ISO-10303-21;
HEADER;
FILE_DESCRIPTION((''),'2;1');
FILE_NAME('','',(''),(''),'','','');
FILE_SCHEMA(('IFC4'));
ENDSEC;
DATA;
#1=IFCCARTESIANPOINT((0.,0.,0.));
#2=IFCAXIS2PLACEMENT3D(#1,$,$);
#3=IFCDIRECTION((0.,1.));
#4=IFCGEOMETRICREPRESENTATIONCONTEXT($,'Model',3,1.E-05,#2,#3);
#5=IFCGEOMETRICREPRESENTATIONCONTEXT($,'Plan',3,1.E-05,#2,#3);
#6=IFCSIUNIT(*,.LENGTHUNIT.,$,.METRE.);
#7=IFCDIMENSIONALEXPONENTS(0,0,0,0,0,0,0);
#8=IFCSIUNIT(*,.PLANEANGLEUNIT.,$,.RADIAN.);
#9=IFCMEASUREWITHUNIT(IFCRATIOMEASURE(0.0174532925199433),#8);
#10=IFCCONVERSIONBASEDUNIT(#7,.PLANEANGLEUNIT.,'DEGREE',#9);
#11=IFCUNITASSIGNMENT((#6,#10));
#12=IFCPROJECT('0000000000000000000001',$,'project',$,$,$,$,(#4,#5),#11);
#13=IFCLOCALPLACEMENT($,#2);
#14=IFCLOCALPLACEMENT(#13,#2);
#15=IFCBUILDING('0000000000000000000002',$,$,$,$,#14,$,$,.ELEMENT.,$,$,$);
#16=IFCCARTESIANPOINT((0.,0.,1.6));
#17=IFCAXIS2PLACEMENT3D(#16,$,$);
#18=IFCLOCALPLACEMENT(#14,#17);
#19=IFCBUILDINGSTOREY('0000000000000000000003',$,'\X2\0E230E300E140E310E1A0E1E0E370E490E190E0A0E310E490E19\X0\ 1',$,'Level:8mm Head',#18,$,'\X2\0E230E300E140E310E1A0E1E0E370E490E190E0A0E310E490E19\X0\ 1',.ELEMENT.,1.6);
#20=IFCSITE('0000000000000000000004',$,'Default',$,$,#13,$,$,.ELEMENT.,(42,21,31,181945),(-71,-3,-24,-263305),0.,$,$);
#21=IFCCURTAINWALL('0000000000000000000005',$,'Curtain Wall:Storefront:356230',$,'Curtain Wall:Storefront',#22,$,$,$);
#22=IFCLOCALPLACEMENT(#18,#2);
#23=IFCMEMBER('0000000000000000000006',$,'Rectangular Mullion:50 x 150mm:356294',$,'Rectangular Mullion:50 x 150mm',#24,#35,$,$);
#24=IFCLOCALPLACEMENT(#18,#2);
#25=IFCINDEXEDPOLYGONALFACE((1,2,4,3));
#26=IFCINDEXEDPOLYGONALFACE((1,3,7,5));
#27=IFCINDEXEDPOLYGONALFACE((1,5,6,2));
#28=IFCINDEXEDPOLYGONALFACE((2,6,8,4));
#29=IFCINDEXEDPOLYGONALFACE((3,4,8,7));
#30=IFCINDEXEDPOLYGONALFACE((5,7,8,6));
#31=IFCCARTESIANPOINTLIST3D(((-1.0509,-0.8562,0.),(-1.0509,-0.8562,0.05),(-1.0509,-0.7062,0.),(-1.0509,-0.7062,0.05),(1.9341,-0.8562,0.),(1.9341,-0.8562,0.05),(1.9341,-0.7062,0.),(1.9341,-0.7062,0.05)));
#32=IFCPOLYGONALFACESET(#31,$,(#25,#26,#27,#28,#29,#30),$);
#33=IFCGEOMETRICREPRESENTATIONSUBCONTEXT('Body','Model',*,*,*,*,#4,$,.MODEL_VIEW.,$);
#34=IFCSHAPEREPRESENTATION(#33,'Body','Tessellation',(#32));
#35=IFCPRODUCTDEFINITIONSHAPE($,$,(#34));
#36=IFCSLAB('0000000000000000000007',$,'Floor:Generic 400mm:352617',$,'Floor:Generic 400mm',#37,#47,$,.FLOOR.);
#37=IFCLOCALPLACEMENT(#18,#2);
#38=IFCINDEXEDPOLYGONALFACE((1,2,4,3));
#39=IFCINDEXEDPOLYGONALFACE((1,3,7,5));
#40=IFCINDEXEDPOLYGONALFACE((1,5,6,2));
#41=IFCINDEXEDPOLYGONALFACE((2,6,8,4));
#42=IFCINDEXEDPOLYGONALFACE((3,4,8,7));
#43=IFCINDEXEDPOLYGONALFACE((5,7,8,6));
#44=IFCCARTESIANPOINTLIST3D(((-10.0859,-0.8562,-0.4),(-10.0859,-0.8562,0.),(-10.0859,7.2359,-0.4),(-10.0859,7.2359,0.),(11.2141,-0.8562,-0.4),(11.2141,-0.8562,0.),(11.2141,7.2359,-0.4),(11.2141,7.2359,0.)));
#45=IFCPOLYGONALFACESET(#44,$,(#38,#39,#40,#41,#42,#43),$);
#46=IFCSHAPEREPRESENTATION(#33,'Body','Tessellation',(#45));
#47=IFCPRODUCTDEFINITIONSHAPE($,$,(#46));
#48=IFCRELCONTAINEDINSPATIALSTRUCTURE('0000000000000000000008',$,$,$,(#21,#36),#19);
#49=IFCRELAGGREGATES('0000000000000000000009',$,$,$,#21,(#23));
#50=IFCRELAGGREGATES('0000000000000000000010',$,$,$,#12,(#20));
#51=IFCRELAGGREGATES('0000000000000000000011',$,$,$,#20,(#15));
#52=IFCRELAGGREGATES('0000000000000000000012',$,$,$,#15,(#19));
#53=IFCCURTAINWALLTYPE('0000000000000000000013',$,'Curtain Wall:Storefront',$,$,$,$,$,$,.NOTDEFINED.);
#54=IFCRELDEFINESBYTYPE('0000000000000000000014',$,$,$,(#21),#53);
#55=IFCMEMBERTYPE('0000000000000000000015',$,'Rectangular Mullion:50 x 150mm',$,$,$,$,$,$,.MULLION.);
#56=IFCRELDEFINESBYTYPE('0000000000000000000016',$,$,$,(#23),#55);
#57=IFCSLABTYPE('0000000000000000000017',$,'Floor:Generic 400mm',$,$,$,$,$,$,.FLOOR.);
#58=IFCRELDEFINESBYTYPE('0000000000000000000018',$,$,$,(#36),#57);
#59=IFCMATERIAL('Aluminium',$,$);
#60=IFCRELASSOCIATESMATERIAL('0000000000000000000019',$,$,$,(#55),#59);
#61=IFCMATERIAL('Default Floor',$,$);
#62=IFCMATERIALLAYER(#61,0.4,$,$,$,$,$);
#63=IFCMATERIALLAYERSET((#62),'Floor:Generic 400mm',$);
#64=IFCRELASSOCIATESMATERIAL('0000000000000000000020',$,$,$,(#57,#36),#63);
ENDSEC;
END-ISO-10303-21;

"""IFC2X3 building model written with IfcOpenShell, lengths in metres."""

from ifc_helpers import new_model, entity, si_unit, converted_unit, direction, frame, origin, origin_2d_with_axis, place, context, subcontext, project, spatial, rectangle, extrude, source, transform, mapped, material, layer, layer_set, layer_usage, type_object, type_shapes, element, aggregate, save


model = new_model("IFC2X3")

# Units and contexts
model_context = context("Model", 3, precision=1e-05, world=origin(), true_north=direction((0.0, 1.0)))
plan_context = context("Plan", 3, precision=1e-05, world=origin(), true_north=direction((0.0, 1.0)))
body_context = subcontext(model_context, "Body", "Model", "MODEL_VIEW")
ifc_project = project(units=[si_unit("LENGTHUNIT", "METRE"), converted_unit("PLANEANGLEUNIT", "DEGREE", entity("IfcRatioMeasure", 0.0174532925199433), si_unit("PLANEANGLEUNIT", "RADIAN"), dimensions=[0, 0, 0, 0, 0, 0, 0])], contexts=[model_context, plan_context])

# Site, building, storey
site_placement = place(None, origin())
site = spatial("IfcSite", under=ifc_project, at=site_placement, Name="Default", CompositionType="ELEMENT", RefLatitude=(42, 21, 31, 181945), RefLongitude=(-71, -3, -24, -263305), RefElevation=0.0)
building_placement = place(site_placement, origin())
building = spatial("IfcBuilding", under=site, at=building_placement, CompositionType="ELEMENT")
storey_placement = place(building_placement, frame((0.0, 0.0, 1.6)))
storey = spatial("IfcBuildingStorey", under=building, at=storey_placement, Name="ระดับพื้นชั้น 1", ObjectType="Level:8mm Head", LongName="ระดับพื้นชั้น 1", CompositionType="ELEMENT", Elevation=1.6)

# Shared definitions
curtain_wall_type = type_object("IfcCurtainWallType", Name="Curtain Wall:Storefront", PredefinedType="NOTDEFINED")
ifc_material_1 = material(Name="Aluminium")

# Curtain wall
curtain_wall_1_placement = place(storey_placement, frame((0.0, 0.0, -1.6)))
curtain_wall_1 = element("IfcCurtainWall", 1, at=curtain_wall_1_placement, inside=storey, type_object=curtain_wall_type, Name="Curtain Wall:Storefront:356230", ObjectType="Curtain Wall:Storefront")

# Member
member_type_1 = type_object("IfcMemberType", Name="Rectangular Mullion:50 x 150mm", PredefinedType="MULLION", material=ifc_material_1)
shared_shape_1 = source(origin(), body_context, "Body", "SweptSolid", [
    extrude(rectangle(XDim=0.15, YDim=0.05, at=origin_2d_with_axis()), frame((-0.025, 0.0, -2.985), z_axis=(0.0, 0.0, 1.0), x_axis=(0.0, -1.0, 0.0)), (0.0, 0.0, 1.0), 2.985),
])
type_shapes(member_type_1, [shared_shape_1])
member_1_placement = place(curtain_wall_1_placement, frame((1.9341, -0.7812, 1.6), z_axis=(1.0, 0.0, 0.0), x_axis=(0.0, 0.0, -1.0)))
member_1 = element("IfcMember", 2, at=member_1_placement, type_object=member_type_1, Name="Rectangular Mullion:50 x 150mm:356294", ObjectType="Rectangular Mullion:50 x 150mm", context=body_context, shape_type="MappedRepresentation", body=[
    mapped(shared_shape_1, transform((0.0, 0.0, 0.0), scale=1.0)),
])

# Slab
ifc_material_2 = material(Name="Default Floor")
ifc_layer = layer(ifc_material_2, 0.4)
ifc_layer_set = layer_set([ifc_layer], Name="Floor:Generic 400mm")
ifc_layer_usage = layer_usage(ifc_layer_set, "AXIS3", "POSITIVE", 0.0)
slab_type = type_object("IfcSlabType", Name="Floor:Generic 400mm", PredefinedType="FLOOR", material=ifc_layer_set)
slab_placement = place(storey_placement, origin())
element("IfcSlab", 3, at=slab_placement, inside=storey, type_object=slab_type, material=ifc_layer_usage, Name="Floor:Generic 400mm:352617", ObjectType="Floor:Generic 400mm", PredefinedType="FLOOR", context=body_context, shape_type="SweptSolid", body=[
    extrude(rectangle(XDim=8.0921, YDim=21.3, at=origin_2d_with_axis()), frame((0.5641, 3.1898, 0.0), z_axis=(0.0, 0.0, -1.0), x_axis=(0.0, 1.0, 0.0)), (0.0, 0.0, 1.0), 0.4),
])

aggregate(curtain_wall_1, [member_1])

save(model, "model.ifc")
